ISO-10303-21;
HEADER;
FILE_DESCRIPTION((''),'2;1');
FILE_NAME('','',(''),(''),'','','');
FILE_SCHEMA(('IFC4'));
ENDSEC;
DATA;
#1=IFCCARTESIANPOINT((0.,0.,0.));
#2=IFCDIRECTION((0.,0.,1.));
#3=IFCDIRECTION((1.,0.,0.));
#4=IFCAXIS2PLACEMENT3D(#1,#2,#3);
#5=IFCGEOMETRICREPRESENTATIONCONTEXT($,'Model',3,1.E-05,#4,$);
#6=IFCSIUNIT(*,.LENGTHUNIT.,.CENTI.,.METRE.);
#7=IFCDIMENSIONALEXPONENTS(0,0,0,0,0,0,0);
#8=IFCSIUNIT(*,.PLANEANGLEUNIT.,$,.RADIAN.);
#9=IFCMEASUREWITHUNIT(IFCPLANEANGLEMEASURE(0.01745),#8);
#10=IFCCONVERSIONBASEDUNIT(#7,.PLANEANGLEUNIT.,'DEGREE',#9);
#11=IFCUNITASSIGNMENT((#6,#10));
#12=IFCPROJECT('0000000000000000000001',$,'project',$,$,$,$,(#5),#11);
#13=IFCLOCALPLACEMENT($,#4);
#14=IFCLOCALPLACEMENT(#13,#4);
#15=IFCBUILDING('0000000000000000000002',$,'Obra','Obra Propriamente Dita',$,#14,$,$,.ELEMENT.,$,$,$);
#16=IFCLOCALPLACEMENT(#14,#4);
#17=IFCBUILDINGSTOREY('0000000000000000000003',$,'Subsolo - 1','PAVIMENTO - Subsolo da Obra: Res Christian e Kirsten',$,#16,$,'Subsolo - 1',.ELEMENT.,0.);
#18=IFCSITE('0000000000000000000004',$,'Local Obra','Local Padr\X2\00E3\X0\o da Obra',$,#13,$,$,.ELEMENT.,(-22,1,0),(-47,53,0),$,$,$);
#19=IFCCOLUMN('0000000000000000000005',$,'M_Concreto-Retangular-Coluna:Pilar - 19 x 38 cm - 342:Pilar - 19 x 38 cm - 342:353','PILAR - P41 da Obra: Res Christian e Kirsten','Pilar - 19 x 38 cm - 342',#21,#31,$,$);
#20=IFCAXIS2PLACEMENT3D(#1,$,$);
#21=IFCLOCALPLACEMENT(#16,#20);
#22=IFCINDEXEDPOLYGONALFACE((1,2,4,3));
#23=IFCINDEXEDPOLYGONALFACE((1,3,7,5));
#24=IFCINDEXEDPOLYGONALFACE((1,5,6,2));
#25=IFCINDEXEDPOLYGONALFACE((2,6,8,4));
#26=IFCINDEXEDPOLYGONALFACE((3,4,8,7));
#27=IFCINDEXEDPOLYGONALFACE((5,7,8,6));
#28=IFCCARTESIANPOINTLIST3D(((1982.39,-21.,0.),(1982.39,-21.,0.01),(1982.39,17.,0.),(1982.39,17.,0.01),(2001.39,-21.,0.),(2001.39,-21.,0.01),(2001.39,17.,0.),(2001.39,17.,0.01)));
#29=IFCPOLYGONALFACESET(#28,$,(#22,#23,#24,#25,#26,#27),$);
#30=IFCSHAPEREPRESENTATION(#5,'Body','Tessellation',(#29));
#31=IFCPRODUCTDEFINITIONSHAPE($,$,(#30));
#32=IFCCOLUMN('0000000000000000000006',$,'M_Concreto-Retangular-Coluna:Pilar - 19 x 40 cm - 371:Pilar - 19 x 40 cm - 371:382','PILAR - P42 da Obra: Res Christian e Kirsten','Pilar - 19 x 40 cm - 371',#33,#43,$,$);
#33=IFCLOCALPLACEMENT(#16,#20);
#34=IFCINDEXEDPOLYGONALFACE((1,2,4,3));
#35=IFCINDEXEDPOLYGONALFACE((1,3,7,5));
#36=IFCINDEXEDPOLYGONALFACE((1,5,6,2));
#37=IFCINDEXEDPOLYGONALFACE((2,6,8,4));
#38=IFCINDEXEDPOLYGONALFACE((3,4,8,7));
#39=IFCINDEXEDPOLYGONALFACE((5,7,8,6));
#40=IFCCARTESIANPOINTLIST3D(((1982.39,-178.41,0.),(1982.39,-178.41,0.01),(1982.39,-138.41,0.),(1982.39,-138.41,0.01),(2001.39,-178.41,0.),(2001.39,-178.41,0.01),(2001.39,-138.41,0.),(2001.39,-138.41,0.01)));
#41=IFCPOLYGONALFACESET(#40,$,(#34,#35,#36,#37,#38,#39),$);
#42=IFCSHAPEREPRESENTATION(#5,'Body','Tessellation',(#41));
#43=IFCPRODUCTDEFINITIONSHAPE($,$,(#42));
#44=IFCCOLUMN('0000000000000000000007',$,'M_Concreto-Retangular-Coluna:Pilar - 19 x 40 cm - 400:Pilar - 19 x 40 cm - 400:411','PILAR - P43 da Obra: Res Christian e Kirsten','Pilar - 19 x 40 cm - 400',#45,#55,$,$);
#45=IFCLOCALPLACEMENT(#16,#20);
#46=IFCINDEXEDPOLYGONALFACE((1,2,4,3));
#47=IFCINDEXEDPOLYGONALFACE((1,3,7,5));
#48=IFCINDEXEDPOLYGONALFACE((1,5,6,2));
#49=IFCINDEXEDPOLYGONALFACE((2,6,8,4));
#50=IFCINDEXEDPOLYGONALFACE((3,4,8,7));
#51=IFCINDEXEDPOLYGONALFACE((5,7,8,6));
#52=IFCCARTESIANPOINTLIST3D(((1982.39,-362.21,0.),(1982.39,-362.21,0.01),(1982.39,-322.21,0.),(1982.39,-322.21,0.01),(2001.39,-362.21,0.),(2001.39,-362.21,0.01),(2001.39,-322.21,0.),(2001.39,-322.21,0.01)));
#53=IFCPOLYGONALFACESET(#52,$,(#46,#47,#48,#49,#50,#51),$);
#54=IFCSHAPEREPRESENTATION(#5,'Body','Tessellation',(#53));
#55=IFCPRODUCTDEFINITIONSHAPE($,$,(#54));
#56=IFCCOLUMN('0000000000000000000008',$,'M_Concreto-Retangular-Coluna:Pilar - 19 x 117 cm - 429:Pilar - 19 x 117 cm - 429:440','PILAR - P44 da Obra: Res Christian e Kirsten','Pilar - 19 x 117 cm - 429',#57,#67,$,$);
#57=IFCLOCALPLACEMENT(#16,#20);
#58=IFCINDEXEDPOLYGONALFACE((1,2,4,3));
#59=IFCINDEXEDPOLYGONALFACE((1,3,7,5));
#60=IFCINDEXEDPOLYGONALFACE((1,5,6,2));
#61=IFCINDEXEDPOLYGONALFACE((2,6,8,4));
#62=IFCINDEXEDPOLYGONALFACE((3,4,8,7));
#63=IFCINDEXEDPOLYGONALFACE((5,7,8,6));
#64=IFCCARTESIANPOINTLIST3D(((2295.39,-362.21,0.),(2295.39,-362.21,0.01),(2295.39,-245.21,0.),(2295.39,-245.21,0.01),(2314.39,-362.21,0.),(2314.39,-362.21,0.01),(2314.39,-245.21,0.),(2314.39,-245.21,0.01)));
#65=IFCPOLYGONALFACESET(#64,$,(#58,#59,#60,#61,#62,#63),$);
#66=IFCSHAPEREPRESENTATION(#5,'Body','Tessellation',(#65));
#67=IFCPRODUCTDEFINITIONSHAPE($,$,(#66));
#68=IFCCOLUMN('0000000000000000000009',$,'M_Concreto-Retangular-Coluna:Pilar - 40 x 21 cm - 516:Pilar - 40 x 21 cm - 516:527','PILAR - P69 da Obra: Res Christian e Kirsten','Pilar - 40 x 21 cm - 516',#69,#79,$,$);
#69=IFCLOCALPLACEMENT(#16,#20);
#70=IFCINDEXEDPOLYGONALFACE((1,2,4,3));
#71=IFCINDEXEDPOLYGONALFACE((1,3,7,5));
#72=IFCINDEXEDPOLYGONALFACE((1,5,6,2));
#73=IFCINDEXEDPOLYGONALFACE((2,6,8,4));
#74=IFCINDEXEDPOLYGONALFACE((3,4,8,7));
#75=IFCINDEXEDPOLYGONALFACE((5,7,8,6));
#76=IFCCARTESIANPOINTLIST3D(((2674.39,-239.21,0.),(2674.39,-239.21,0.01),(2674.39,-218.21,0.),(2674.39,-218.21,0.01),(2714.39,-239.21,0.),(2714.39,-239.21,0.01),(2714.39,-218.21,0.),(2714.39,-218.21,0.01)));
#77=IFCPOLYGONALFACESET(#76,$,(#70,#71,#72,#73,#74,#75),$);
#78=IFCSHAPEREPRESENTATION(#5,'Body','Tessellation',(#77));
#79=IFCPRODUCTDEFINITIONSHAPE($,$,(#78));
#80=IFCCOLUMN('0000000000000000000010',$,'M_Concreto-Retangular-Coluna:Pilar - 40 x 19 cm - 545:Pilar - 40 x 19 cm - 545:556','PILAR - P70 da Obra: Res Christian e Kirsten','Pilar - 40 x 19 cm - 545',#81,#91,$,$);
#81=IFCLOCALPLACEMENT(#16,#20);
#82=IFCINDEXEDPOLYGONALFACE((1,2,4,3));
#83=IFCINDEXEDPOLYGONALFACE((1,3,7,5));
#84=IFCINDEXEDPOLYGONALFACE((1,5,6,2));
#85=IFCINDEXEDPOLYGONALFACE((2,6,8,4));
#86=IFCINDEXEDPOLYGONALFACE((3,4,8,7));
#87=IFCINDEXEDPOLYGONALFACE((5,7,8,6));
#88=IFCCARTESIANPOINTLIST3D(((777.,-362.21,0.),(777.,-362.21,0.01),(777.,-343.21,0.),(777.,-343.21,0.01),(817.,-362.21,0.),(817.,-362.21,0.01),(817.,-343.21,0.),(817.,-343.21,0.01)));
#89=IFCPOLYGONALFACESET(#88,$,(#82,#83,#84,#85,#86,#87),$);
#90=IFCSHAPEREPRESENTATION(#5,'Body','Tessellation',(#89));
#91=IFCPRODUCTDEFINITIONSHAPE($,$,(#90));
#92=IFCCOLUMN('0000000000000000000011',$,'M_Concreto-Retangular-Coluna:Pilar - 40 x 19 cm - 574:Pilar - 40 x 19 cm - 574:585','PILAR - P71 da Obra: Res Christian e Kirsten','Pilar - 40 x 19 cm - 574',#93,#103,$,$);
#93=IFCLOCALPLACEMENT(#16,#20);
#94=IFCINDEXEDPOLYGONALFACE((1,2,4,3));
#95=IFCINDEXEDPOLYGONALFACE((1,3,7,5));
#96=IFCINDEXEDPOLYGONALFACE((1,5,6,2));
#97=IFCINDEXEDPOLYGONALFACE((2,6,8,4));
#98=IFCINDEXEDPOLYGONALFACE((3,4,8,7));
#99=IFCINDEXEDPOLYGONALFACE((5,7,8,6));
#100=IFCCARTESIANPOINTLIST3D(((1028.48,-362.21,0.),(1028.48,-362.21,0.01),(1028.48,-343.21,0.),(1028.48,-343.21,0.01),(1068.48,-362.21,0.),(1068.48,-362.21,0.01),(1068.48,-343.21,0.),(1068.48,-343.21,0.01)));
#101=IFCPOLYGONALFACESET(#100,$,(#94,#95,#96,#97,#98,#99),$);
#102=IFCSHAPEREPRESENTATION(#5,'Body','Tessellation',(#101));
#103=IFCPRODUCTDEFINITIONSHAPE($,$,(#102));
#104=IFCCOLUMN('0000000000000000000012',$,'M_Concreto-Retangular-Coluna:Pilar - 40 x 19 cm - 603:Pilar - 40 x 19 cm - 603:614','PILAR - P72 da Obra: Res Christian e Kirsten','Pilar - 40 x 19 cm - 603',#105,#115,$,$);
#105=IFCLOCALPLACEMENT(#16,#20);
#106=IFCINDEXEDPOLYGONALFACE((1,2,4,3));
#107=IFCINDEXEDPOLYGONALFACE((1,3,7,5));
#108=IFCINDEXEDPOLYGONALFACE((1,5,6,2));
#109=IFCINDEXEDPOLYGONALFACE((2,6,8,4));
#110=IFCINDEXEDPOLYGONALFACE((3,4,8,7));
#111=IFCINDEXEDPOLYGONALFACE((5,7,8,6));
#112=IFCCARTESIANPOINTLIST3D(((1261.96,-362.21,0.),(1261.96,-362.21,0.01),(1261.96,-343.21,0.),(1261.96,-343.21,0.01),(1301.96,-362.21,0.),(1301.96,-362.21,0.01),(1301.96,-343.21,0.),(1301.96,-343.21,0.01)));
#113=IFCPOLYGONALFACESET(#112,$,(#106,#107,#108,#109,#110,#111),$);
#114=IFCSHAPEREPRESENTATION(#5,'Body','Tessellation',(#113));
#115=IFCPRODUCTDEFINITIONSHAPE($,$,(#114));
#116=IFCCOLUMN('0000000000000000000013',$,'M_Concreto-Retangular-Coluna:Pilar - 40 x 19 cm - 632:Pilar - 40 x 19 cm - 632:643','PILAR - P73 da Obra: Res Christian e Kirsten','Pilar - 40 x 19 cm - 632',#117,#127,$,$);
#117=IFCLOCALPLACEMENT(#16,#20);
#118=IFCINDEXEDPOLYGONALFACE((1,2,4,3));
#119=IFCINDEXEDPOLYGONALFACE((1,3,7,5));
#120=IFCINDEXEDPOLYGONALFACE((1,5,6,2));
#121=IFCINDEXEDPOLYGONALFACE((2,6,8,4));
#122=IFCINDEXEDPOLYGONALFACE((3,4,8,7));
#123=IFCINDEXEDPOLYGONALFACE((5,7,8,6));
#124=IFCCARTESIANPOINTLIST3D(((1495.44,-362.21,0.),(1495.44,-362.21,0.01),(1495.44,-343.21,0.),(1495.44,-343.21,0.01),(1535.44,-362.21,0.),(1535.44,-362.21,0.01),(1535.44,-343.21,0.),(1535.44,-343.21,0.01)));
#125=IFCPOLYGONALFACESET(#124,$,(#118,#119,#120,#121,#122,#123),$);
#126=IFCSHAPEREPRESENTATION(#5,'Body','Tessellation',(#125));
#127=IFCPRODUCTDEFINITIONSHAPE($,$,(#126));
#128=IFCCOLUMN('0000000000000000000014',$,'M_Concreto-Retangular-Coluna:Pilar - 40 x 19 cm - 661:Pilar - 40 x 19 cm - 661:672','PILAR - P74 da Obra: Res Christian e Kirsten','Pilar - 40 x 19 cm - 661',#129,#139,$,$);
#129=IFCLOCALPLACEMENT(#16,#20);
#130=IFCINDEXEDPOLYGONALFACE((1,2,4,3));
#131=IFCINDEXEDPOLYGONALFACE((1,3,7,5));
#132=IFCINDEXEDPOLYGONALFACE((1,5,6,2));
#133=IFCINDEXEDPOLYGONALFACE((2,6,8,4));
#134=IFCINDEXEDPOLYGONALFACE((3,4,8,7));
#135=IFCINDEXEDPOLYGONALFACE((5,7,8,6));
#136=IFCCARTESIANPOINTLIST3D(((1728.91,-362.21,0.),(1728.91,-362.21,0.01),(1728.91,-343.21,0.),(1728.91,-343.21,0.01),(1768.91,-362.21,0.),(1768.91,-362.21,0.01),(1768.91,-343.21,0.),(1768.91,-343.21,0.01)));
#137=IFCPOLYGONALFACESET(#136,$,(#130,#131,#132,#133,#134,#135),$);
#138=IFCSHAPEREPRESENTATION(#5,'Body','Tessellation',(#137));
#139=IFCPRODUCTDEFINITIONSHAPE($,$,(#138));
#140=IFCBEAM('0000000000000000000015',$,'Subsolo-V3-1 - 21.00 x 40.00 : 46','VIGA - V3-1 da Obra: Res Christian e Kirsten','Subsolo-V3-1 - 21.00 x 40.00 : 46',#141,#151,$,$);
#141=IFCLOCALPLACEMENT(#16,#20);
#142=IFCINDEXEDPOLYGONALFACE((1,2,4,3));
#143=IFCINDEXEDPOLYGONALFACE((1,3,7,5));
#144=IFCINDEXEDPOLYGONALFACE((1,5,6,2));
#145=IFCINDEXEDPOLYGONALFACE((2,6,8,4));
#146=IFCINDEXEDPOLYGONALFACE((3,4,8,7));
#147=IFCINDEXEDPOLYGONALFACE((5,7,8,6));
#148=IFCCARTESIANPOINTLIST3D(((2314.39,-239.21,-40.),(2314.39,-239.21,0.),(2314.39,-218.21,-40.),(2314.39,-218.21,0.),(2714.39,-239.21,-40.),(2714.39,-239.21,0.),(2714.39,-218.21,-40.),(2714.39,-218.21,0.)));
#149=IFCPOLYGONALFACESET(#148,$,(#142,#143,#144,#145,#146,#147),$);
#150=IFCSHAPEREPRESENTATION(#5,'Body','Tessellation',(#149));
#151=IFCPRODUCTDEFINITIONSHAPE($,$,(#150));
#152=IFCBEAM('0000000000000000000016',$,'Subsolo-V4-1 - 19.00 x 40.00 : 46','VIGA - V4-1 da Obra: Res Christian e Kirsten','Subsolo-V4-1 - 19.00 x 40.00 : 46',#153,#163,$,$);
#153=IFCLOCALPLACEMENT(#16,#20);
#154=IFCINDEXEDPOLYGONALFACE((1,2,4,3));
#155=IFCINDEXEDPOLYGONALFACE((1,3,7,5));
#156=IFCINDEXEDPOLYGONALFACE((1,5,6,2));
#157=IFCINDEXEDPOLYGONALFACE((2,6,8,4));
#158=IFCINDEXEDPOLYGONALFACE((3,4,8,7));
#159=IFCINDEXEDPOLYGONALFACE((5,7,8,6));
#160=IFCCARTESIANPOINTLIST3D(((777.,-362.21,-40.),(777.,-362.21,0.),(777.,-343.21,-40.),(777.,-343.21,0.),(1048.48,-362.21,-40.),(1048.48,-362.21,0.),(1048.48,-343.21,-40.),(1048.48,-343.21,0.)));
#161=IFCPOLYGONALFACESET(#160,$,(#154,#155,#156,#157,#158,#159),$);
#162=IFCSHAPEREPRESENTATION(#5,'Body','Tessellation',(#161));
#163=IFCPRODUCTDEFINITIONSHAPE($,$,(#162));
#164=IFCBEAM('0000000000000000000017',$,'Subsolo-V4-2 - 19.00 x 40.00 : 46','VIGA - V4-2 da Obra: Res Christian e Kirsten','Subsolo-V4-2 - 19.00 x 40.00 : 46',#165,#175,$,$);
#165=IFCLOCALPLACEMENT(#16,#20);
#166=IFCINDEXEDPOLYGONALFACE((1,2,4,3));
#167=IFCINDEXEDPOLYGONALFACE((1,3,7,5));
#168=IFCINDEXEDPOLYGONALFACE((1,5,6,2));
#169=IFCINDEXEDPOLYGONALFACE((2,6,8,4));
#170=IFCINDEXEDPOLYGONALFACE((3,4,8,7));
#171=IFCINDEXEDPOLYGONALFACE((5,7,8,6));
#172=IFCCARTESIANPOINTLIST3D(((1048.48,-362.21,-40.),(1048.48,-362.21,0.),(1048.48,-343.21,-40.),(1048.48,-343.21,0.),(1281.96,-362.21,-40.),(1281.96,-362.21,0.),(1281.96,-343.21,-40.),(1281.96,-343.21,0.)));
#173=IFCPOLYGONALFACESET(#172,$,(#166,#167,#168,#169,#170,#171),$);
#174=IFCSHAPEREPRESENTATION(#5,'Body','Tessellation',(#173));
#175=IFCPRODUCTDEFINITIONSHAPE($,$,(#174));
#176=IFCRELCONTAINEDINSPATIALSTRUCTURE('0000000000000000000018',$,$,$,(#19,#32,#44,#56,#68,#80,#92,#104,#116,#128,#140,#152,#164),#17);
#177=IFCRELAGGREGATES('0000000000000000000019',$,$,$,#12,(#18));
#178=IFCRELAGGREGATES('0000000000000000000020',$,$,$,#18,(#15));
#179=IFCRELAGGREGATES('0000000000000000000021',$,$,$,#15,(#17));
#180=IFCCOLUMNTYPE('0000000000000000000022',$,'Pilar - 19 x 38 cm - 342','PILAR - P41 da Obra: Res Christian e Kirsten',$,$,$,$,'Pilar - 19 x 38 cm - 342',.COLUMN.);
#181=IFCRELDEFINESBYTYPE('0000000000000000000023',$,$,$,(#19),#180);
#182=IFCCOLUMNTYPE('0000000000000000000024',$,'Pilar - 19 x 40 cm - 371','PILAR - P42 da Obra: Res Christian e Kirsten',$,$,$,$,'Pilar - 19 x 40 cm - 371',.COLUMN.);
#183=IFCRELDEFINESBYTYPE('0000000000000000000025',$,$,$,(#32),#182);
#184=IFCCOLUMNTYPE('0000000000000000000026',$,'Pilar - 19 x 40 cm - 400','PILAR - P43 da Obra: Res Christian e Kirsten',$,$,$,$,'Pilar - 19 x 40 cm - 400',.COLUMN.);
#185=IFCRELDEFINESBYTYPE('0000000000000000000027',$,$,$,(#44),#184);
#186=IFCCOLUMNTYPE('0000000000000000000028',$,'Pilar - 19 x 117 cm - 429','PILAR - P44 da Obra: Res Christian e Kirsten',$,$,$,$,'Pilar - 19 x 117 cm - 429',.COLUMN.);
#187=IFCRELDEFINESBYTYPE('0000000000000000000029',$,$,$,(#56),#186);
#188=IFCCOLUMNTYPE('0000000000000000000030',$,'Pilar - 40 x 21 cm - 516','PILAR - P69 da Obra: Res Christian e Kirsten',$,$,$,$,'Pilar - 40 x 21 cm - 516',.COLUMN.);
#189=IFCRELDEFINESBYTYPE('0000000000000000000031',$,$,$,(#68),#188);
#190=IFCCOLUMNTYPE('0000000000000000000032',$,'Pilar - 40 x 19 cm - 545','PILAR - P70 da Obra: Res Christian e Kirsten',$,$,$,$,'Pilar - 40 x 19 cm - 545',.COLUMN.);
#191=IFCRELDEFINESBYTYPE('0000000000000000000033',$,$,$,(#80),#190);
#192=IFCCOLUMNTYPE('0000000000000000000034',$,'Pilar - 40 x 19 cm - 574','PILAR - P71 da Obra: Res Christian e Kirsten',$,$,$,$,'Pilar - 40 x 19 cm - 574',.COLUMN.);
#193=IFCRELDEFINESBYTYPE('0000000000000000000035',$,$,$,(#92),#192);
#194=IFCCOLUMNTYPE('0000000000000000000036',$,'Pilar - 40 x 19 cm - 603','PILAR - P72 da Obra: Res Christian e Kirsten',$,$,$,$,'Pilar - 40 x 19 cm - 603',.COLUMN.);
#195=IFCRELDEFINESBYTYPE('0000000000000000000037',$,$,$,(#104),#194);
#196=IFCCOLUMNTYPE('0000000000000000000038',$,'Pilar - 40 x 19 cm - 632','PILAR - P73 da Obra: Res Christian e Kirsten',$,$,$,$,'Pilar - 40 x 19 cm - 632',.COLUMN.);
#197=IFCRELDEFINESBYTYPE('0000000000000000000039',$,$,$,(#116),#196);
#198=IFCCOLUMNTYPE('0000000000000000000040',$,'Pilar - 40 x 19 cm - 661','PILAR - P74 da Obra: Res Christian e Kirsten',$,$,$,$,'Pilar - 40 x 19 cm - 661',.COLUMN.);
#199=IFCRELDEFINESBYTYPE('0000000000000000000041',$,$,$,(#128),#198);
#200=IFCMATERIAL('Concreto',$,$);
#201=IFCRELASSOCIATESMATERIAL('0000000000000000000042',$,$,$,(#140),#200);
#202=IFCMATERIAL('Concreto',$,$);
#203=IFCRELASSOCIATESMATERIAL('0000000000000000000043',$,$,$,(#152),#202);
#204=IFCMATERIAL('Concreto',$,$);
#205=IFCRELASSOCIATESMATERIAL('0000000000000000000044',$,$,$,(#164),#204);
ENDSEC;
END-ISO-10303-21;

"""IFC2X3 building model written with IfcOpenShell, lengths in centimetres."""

from ifc_helpers import new_model, entity, si_unit, converted_unit, frame, origin, origin_with_axes, origin_2d_with_axis, place, context, project, spatial, polyline, rectangle, outline, extrude, source, transform, mapped, material, type_object, type_shapes, element, save


model = new_model("IFC2X3")

# Units and contexts
model_context = context("Model", 3, precision=1e-05, world=origin_with_axes())
ifc_project = project(units=[si_unit("LENGTHUNIT", "METRE", prefix="CENTI"), converted_unit("PLANEANGLEUNIT", "DEGREE", entity("IfcPlaneAngleMeasure", 0.01745), si_unit("PLANEANGLEUNIT", "RADIAN"), dimensions=[0, 0, 0, 0, 0, 0, 0])], contexts=[model_context])

# Site, building, storey
site_placement = place(None, origin_with_axes())
site = spatial("IfcSite", under=ifc_project, at=site_placement, Name="Local Obra", Description="Local Padrão da Obra", CompositionType="ELEMENT", RefLatitude=(-22, 1, 0), RefLongitude=(-47, 53, 0))
building_placement = place(site_placement, origin_with_axes())
building = spatial("IfcBuilding", under=site, at=building_placement, Name="Obra", Description="Obra Propriamente Dita", CompositionType="ELEMENT")
storey_placement = place(building_placement, origin_with_axes())
storey = spatial("IfcBuildingStorey", under=building, at=storey_placement, Name="Subsolo - 1", Description="PAVIMENTO - Subsolo da Obra: Res Christian e Kirsten", LongName="Subsolo - 1", CompositionType="ELEMENT", Elevation=0.0)

# Columns
column_type_1 = type_object("IfcColumnType", Name="Pilar - 19 x 38 cm - 342", Description="PILAR - P41 da Obra: Res Christian e Kirsten", ElementType="Pilar - 19 x 38 cm - 342", PredefinedType="COLUMN")
shared_shape_1 = source(origin(), model_context, "Body", "SweptSolid", [
    extrude(rectangle(XDim=19.0, YDim=38.0, at=origin_2d_with_axis()), origin(), (0.0, 0.0, 1.0), 0.01),
])
type_shapes(column_type_1, [shared_shape_1])
column_1_placement = place(storey_placement, frame((1991.89, -2.0, 0.0), z_axis=(0.0, 0.0, 1.0), x_axis=(1.0, 0.0, 0.0)))
element("IfcColumn", 1, at=column_1_placement, inside=storey, type_object=column_type_1, Name="M_Concreto-Retangular-Coluna:Pilar - 19 x 38 cm - 342:Pilar - 19 x 38 cm - 342:353", Description="PILAR - P41 da Obra: Res Christian e Kirsten", ObjectType="Pilar - 19 x 38 cm - 342", context=model_context, shape_type="MappedRepresentation", body=[
    mapped(shared_shape_1, transform((0.0, 0.0, 0.0), scale=1.0)),
])
column_type_2 = type_object("IfcColumnType", Name="Pilar - 19 x 40 cm - 371", Description="PILAR - P42 da Obra: Res Christian e Kirsten", ElementType="Pilar - 19 x 40 cm - 371", PredefinedType="COLUMN")
shared_shape_2 = source(origin(), model_context, "Body", "SweptSolid", [
    extrude(rectangle(XDim=19.0, YDim=40.0, at=origin_2d_with_axis()), origin(), (0.0, 0.0, 1.0), 0.01),
])
type_shapes(column_type_2, [shared_shape_2])
column_2_placement = place(storey_placement, frame((1991.89, -158.41, 0.0), z_axis=(0.0, 0.0, 1.0), x_axis=(1.0, 0.0, 0.0)))
element("IfcColumn", 2, at=column_2_placement, inside=storey, type_object=column_type_2, Name="M_Concreto-Retangular-Coluna:Pilar - 19 x 40 cm - 371:Pilar - 19 x 40 cm - 371:382", Description="PILAR - P42 da Obra: Res Christian e Kirsten", ObjectType="Pilar - 19 x 40 cm - 371", context=model_context, shape_type="MappedRepresentation", body=[
    mapped(shared_shape_2, transform((0.0, 0.0, 0.0), scale=1.0)),
])
column_type_3 = type_object("IfcColumnType", Name="Pilar - 19 x 40 cm - 400", Description="PILAR - P43 da Obra: Res Christian e Kirsten", ElementType="Pilar - 19 x 40 cm - 400", PredefinedType="COLUMN")
shared_shape_3 = source(origin(), model_context, "Body", "SweptSolid", [
    extrude(rectangle(XDim=19.0, YDim=40.0, at=origin_2d_with_axis()), origin(), (0.0, 0.0, 1.0), 0.01),
])
type_shapes(column_type_3, [shared_shape_3])
column_3_placement = place(storey_placement, frame((1991.89, -342.21, 0.0), z_axis=(0.0, 0.0, 1.0), x_axis=(1.0, 0.0, 0.0)))
element("IfcColumn", 3, at=column_3_placement, inside=storey, type_object=column_type_3, Name="M_Concreto-Retangular-Coluna:Pilar - 19 x 40 cm - 400:Pilar - 19 x 40 cm - 400:411", Description="PILAR - P43 da Obra: Res Christian e Kirsten", ObjectType="Pilar - 19 x 40 cm - 400", context=model_context, shape_type="MappedRepresentation", body=[
    mapped(shared_shape_3, transform((0.0, 0.0, 0.0), scale=1.0)),
])
column_type_4 = type_object("IfcColumnType", Name="Pilar - 19 x 117 cm - 429", Description="PILAR - P44 da Obra: Res Christian e Kirsten", ElementType="Pilar - 19 x 117 cm - 429", PredefinedType="COLUMN")
shared_shape_4 = source(origin(), model_context, "Body", "SweptSolid", [
    extrude(rectangle(XDim=19.0, YDim=117.0, at=origin_2d_with_axis()), origin(), (0.0, 0.0, 1.0), 0.01),
])
type_shapes(column_type_4, [shared_shape_4])
column_4_placement = place(storey_placement, frame((2304.89, -303.71, 0.0), z_axis=(0.0, 0.0, 1.0), x_axis=(1.0, 0.0, 0.0)))
element("IfcColumn", 4, at=column_4_placement, inside=storey, type_object=column_type_4, Name="M_Concreto-Retangular-Coluna:Pilar - 19 x 117 cm - 429:Pilar - 19 x 117 cm - 429:440", Description="PILAR - P44 da Obra: Res Christian e Kirsten", ObjectType="Pilar - 19 x 117 cm - 429", context=model_context, shape_type="MappedRepresentation", body=[
    mapped(shared_shape_4, transform((0.0, 0.0, 0.0), scale=1.0)),
])
column_type_5 = type_object("IfcColumnType", Name="Pilar - 40 x 21 cm - 516", Description="PILAR - P69 da Obra: Res Christian e Kirsten", ElementType="Pilar - 40 x 21 cm - 516", PredefinedType="COLUMN")
shared_shape_5 = source(origin(), model_context, "Body", "SweptSolid", [
    extrude(rectangle(XDim=40.0, YDim=21.0, at=origin_2d_with_axis()), origin(), (0.0, 0.0, 1.0), 0.01),
])
type_shapes(column_type_5, [shared_shape_5])
column_5_placement = place(storey_placement, frame((2694.39, -228.71, 0.0), z_axis=(0.0, 0.0, 1.0), x_axis=(1.0, 0.0, 0.0)))
element("IfcColumn", 5, at=column_5_placement, inside=storey, type_object=column_type_5, Name="M_Concreto-Retangular-Coluna:Pilar - 40 x 21 cm - 516:Pilar - 40 x 21 cm - 516:527", Description="PILAR - P69 da Obra: Res Christian e Kirsten", ObjectType="Pilar - 40 x 21 cm - 516", context=model_context, shape_type="MappedRepresentation", body=[
    mapped(shared_shape_5, transform((0.0, 0.0, 0.0), scale=1.0)),
])
column_type_6 = type_object("IfcColumnType", Name="Pilar - 40 x 19 cm - 545", Description="PILAR - P70 da Obra: Res Christian e Kirsten", ElementType="Pilar - 40 x 19 cm - 545", PredefinedType="COLUMN")
shared_shape_6 = source(origin(), model_context, "Body", "SweptSolid", [
    extrude(rectangle(XDim=40.0, YDim=19.0, at=origin_2d_with_axis()), origin(), (0.0, 0.0, 1.0), 0.01),
])
type_shapes(column_type_6, [shared_shape_6])
column_6_placement = place(storey_placement, frame((797.0, -352.71, 0.0), z_axis=(0.0, 0.0, 1.0), x_axis=(1.0, 0.0, 0.0)))
element("IfcColumn", 6, at=column_6_placement, inside=storey, type_object=column_type_6, Name="M_Concreto-Retangular-Coluna:Pilar - 40 x 19 cm - 545:Pilar - 40 x 19 cm - 545:556", Description="PILAR - P70 da Obra: Res Christian e Kirsten", ObjectType="Pilar - 40 x 19 cm - 545", context=model_context, shape_type="MappedRepresentation", body=[
    mapped(shared_shape_6, transform((0.0, 0.0, 0.0), scale=1.0)),
])
column_type_7 = type_object("IfcColumnType", Name="Pilar - 40 x 19 cm - 574", Description="PILAR - P71 da Obra: Res Christian e Kirsten", ElementType="Pilar - 40 x 19 cm - 574", PredefinedType="COLUMN")
shared_shape_7 = source(origin(), model_context, "Body", "SweptSolid", [
    extrude(rectangle(XDim=40.0, YDim=19.0, at=origin_2d_with_axis()), origin(), (0.0, 0.0, 1.0), 0.01),
])
type_shapes(column_type_7, [shared_shape_7])
column_7_placement = place(storey_placement, frame((1048.48, -352.71, 0.0), z_axis=(0.0, 0.0, 1.0), x_axis=(1.0, 0.0, 0.0)))
element("IfcColumn", 7, at=column_7_placement, inside=storey, type_object=column_type_7, Name="M_Concreto-Retangular-Coluna:Pilar - 40 x 19 cm - 574:Pilar - 40 x 19 cm - 574:585", Description="PILAR - P71 da Obra: Res Christian e Kirsten", ObjectType="Pilar - 40 x 19 cm - 574", context=model_context, shape_type="MappedRepresentation", body=[
    mapped(shared_shape_7, transform((0.0, 0.0, 0.0), scale=1.0)),
])
column_type_8 = type_object("IfcColumnType", Name="Pilar - 40 x 19 cm - 603", Description="PILAR - P72 da Obra: Res Christian e Kirsten", ElementType="Pilar - 40 x 19 cm - 603", PredefinedType="COLUMN")
shared_shape_8 = source(origin(), model_context, "Body", "SweptSolid", [
    extrude(rectangle(XDim=40.0, YDim=19.0, at=origin_2d_with_axis()), origin(), (0.0, 0.0, 1.0), 0.01),
])
type_shapes(column_type_8, [shared_shape_8])
column_8_placement = place(storey_placement, frame((1281.96, -352.71, 0.0), z_axis=(0.0, 0.0, 1.0), x_axis=(1.0, 0.0, 0.0)))
element("IfcColumn", 8, at=column_8_placement, inside=storey, type_object=column_type_8, Name="M_Concreto-Retangular-Coluna:Pilar - 40 x 19 cm - 603:Pilar - 40 x 19 cm - 603:614", Description="PILAR - P72 da Obra: Res Christian e Kirsten", ObjectType="Pilar - 40 x 19 cm - 603", context=model_context, shape_type="MappedRepresentation", body=[
    mapped(shared_shape_8, transform((0.0, 0.0, 0.0), scale=1.0)),
])
column_type_9 = type_object("IfcColumnType", Name="Pilar - 40 x 19 cm - 632", Description="PILAR - P73 da Obra: Res Christian e Kirsten", ElementType="Pilar - 40 x 19 cm - 632", PredefinedType="COLUMN")
shared_shape_9 = source(origin(), model_context, "Body", "SweptSolid", [
    extrude(rectangle(XDim=40.0, YDim=19.0, at=origin_2d_with_axis()), origin(), (0.0, 0.0, 1.0), 0.01),
])
type_shapes(column_type_9, [shared_shape_9])
column_9_placement = place(storey_placement, frame((1515.44, -352.71, 0.0), z_axis=(0.0, 0.0, 1.0), x_axis=(1.0, 0.0, 0.0)))
element("IfcColumn", 9, at=column_9_placement, inside=storey, type_object=column_type_9, Name="M_Concreto-Retangular-Coluna:Pilar - 40 x 19 cm - 632:Pilar - 40 x 19 cm - 632:643", Description="PILAR - P73 da Obra: Res Christian e Kirsten", ObjectType="Pilar - 40 x 19 cm - 632", context=model_context, shape_type="MappedRepresentation", body=[
    mapped(shared_shape_9, transform((0.0, 0.0, 0.0), scale=1.0)),
])
column_type_10 = type_object("IfcColumnType", Name="Pilar - 40 x 19 cm - 661", Description="PILAR - P74 da Obra: Res Christian e Kirsten", ElementType="Pilar - 40 x 19 cm - 661", PredefinedType="COLUMN")
shared_shape_10 = source(origin(), model_context, "Body", "SweptSolid", [
    extrude(rectangle(XDim=40.0, YDim=19.0, at=origin_2d_with_axis()), origin(), (0.0, 0.0, 1.0), 0.01),
])
type_shapes(column_type_10, [shared_shape_10])
column_10_placement = place(storey_placement, frame((1748.91, -352.71, 0.0), z_axis=(0.0, 0.0, 1.0), x_axis=(1.0, 0.0, 0.0)))
element("IfcColumn", 10, at=column_10_placement, inside=storey, type_object=column_type_10, Name="M_Concreto-Retangular-Coluna:Pilar - 40 x 19 cm - 661:Pilar - 40 x 19 cm - 661:672", Description="PILAR - P74 da Obra: Res Christian e Kirsten", ObjectType="Pilar - 40 x 19 cm - 661", context=model_context, shape_type="MappedRepresentation", body=[
    mapped(shared_shape_10, transform((0.0, 0.0, 0.0), scale=1.0)),
])

# Beams
ifc_material_1 = material(Name="Concreto")
beam_1_placement = place(storey_placement, frame((2314.39, -218.21, 0.0), z_axis=(1.0, 0.0, 0.0), x_axis=(0.0, -1.0, 0.0)))
element("IfcBeam", 11, at=beam_1_placement, inside=storey, material=ifc_material_1, Name="Subsolo-V3-1 - 21.00 x 40.00 : 46", Description="VIGA - V3-1 da Obra: Res Christian e Kirsten", ObjectType="Subsolo-V3-1 - 21.00 x 40.00 : 46", context=model_context, shape_type="SweptSolid", body=[
    extrude(outline(polyline([(0.0, 0.0), (21.0, 0.0), (21.0, 40.0), (0.0, 40.0), (0.0, 0.0)])), origin_with_axes(), (0.0, 0.0, 1.0), 400.0),
])
ifc_material_2 = material(Name="Concreto")
beam_2_placement = place(storey_placement, frame((777.0, -362.21, 0.0), z_axis=(1.0, 0.0, 0.0), x_axis=(0.0, -1.0, 0.0)))
element("IfcBeam", 12, at=beam_2_placement, inside=storey, material=ifc_material_2, Name="Subsolo-V4-1 - 19.00 x 40.00 : 46", Description="VIGA - V4-1 da Obra: Res Christian e Kirsten", ObjectType="Subsolo-V4-1 - 19.00 x 40.00 : 46", context=model_context, shape_type="SweptSolid", body=[
    extrude(outline(polyline([(-19.0, 0.0), (0.0, 0.0), (0.0, 40.0), (-19.0, 40.0), (-19.0, 0.0)])), origin_with_axes(), (0.0, 0.0, 1.0), 271.48),
])
ifc_material_3 = material(Name="Concreto")
beam_3_placement = place(storey_placement, frame((1048.48, -362.21, 0.0), z_axis=(1.0, 0.0, 0.0), x_axis=(0.0, -1.0, 0.0)))
element("IfcBeam", 13, at=beam_3_placement, inside=storey, material=ifc_material_3, Name="Subsolo-V4-2 - 19.00 x 40.00 : 46", Description="VIGA - V4-2 da Obra: Res Christian e Kirsten", ObjectType="Subsolo-V4-2 - 19.00 x 40.00 : 46", context=model_context, shape_type="SweptSolid", body=[
    extrude(outline(polyline([(-19.0, 0.0), (0.0, 0.0), (0.0, 40.0), (-19.0, 40.0), (-19.0, 0.0)])), origin_with_axes(), (0.0, 0.0, 1.0), 233.48),
])

save(model, "model.ifc")
